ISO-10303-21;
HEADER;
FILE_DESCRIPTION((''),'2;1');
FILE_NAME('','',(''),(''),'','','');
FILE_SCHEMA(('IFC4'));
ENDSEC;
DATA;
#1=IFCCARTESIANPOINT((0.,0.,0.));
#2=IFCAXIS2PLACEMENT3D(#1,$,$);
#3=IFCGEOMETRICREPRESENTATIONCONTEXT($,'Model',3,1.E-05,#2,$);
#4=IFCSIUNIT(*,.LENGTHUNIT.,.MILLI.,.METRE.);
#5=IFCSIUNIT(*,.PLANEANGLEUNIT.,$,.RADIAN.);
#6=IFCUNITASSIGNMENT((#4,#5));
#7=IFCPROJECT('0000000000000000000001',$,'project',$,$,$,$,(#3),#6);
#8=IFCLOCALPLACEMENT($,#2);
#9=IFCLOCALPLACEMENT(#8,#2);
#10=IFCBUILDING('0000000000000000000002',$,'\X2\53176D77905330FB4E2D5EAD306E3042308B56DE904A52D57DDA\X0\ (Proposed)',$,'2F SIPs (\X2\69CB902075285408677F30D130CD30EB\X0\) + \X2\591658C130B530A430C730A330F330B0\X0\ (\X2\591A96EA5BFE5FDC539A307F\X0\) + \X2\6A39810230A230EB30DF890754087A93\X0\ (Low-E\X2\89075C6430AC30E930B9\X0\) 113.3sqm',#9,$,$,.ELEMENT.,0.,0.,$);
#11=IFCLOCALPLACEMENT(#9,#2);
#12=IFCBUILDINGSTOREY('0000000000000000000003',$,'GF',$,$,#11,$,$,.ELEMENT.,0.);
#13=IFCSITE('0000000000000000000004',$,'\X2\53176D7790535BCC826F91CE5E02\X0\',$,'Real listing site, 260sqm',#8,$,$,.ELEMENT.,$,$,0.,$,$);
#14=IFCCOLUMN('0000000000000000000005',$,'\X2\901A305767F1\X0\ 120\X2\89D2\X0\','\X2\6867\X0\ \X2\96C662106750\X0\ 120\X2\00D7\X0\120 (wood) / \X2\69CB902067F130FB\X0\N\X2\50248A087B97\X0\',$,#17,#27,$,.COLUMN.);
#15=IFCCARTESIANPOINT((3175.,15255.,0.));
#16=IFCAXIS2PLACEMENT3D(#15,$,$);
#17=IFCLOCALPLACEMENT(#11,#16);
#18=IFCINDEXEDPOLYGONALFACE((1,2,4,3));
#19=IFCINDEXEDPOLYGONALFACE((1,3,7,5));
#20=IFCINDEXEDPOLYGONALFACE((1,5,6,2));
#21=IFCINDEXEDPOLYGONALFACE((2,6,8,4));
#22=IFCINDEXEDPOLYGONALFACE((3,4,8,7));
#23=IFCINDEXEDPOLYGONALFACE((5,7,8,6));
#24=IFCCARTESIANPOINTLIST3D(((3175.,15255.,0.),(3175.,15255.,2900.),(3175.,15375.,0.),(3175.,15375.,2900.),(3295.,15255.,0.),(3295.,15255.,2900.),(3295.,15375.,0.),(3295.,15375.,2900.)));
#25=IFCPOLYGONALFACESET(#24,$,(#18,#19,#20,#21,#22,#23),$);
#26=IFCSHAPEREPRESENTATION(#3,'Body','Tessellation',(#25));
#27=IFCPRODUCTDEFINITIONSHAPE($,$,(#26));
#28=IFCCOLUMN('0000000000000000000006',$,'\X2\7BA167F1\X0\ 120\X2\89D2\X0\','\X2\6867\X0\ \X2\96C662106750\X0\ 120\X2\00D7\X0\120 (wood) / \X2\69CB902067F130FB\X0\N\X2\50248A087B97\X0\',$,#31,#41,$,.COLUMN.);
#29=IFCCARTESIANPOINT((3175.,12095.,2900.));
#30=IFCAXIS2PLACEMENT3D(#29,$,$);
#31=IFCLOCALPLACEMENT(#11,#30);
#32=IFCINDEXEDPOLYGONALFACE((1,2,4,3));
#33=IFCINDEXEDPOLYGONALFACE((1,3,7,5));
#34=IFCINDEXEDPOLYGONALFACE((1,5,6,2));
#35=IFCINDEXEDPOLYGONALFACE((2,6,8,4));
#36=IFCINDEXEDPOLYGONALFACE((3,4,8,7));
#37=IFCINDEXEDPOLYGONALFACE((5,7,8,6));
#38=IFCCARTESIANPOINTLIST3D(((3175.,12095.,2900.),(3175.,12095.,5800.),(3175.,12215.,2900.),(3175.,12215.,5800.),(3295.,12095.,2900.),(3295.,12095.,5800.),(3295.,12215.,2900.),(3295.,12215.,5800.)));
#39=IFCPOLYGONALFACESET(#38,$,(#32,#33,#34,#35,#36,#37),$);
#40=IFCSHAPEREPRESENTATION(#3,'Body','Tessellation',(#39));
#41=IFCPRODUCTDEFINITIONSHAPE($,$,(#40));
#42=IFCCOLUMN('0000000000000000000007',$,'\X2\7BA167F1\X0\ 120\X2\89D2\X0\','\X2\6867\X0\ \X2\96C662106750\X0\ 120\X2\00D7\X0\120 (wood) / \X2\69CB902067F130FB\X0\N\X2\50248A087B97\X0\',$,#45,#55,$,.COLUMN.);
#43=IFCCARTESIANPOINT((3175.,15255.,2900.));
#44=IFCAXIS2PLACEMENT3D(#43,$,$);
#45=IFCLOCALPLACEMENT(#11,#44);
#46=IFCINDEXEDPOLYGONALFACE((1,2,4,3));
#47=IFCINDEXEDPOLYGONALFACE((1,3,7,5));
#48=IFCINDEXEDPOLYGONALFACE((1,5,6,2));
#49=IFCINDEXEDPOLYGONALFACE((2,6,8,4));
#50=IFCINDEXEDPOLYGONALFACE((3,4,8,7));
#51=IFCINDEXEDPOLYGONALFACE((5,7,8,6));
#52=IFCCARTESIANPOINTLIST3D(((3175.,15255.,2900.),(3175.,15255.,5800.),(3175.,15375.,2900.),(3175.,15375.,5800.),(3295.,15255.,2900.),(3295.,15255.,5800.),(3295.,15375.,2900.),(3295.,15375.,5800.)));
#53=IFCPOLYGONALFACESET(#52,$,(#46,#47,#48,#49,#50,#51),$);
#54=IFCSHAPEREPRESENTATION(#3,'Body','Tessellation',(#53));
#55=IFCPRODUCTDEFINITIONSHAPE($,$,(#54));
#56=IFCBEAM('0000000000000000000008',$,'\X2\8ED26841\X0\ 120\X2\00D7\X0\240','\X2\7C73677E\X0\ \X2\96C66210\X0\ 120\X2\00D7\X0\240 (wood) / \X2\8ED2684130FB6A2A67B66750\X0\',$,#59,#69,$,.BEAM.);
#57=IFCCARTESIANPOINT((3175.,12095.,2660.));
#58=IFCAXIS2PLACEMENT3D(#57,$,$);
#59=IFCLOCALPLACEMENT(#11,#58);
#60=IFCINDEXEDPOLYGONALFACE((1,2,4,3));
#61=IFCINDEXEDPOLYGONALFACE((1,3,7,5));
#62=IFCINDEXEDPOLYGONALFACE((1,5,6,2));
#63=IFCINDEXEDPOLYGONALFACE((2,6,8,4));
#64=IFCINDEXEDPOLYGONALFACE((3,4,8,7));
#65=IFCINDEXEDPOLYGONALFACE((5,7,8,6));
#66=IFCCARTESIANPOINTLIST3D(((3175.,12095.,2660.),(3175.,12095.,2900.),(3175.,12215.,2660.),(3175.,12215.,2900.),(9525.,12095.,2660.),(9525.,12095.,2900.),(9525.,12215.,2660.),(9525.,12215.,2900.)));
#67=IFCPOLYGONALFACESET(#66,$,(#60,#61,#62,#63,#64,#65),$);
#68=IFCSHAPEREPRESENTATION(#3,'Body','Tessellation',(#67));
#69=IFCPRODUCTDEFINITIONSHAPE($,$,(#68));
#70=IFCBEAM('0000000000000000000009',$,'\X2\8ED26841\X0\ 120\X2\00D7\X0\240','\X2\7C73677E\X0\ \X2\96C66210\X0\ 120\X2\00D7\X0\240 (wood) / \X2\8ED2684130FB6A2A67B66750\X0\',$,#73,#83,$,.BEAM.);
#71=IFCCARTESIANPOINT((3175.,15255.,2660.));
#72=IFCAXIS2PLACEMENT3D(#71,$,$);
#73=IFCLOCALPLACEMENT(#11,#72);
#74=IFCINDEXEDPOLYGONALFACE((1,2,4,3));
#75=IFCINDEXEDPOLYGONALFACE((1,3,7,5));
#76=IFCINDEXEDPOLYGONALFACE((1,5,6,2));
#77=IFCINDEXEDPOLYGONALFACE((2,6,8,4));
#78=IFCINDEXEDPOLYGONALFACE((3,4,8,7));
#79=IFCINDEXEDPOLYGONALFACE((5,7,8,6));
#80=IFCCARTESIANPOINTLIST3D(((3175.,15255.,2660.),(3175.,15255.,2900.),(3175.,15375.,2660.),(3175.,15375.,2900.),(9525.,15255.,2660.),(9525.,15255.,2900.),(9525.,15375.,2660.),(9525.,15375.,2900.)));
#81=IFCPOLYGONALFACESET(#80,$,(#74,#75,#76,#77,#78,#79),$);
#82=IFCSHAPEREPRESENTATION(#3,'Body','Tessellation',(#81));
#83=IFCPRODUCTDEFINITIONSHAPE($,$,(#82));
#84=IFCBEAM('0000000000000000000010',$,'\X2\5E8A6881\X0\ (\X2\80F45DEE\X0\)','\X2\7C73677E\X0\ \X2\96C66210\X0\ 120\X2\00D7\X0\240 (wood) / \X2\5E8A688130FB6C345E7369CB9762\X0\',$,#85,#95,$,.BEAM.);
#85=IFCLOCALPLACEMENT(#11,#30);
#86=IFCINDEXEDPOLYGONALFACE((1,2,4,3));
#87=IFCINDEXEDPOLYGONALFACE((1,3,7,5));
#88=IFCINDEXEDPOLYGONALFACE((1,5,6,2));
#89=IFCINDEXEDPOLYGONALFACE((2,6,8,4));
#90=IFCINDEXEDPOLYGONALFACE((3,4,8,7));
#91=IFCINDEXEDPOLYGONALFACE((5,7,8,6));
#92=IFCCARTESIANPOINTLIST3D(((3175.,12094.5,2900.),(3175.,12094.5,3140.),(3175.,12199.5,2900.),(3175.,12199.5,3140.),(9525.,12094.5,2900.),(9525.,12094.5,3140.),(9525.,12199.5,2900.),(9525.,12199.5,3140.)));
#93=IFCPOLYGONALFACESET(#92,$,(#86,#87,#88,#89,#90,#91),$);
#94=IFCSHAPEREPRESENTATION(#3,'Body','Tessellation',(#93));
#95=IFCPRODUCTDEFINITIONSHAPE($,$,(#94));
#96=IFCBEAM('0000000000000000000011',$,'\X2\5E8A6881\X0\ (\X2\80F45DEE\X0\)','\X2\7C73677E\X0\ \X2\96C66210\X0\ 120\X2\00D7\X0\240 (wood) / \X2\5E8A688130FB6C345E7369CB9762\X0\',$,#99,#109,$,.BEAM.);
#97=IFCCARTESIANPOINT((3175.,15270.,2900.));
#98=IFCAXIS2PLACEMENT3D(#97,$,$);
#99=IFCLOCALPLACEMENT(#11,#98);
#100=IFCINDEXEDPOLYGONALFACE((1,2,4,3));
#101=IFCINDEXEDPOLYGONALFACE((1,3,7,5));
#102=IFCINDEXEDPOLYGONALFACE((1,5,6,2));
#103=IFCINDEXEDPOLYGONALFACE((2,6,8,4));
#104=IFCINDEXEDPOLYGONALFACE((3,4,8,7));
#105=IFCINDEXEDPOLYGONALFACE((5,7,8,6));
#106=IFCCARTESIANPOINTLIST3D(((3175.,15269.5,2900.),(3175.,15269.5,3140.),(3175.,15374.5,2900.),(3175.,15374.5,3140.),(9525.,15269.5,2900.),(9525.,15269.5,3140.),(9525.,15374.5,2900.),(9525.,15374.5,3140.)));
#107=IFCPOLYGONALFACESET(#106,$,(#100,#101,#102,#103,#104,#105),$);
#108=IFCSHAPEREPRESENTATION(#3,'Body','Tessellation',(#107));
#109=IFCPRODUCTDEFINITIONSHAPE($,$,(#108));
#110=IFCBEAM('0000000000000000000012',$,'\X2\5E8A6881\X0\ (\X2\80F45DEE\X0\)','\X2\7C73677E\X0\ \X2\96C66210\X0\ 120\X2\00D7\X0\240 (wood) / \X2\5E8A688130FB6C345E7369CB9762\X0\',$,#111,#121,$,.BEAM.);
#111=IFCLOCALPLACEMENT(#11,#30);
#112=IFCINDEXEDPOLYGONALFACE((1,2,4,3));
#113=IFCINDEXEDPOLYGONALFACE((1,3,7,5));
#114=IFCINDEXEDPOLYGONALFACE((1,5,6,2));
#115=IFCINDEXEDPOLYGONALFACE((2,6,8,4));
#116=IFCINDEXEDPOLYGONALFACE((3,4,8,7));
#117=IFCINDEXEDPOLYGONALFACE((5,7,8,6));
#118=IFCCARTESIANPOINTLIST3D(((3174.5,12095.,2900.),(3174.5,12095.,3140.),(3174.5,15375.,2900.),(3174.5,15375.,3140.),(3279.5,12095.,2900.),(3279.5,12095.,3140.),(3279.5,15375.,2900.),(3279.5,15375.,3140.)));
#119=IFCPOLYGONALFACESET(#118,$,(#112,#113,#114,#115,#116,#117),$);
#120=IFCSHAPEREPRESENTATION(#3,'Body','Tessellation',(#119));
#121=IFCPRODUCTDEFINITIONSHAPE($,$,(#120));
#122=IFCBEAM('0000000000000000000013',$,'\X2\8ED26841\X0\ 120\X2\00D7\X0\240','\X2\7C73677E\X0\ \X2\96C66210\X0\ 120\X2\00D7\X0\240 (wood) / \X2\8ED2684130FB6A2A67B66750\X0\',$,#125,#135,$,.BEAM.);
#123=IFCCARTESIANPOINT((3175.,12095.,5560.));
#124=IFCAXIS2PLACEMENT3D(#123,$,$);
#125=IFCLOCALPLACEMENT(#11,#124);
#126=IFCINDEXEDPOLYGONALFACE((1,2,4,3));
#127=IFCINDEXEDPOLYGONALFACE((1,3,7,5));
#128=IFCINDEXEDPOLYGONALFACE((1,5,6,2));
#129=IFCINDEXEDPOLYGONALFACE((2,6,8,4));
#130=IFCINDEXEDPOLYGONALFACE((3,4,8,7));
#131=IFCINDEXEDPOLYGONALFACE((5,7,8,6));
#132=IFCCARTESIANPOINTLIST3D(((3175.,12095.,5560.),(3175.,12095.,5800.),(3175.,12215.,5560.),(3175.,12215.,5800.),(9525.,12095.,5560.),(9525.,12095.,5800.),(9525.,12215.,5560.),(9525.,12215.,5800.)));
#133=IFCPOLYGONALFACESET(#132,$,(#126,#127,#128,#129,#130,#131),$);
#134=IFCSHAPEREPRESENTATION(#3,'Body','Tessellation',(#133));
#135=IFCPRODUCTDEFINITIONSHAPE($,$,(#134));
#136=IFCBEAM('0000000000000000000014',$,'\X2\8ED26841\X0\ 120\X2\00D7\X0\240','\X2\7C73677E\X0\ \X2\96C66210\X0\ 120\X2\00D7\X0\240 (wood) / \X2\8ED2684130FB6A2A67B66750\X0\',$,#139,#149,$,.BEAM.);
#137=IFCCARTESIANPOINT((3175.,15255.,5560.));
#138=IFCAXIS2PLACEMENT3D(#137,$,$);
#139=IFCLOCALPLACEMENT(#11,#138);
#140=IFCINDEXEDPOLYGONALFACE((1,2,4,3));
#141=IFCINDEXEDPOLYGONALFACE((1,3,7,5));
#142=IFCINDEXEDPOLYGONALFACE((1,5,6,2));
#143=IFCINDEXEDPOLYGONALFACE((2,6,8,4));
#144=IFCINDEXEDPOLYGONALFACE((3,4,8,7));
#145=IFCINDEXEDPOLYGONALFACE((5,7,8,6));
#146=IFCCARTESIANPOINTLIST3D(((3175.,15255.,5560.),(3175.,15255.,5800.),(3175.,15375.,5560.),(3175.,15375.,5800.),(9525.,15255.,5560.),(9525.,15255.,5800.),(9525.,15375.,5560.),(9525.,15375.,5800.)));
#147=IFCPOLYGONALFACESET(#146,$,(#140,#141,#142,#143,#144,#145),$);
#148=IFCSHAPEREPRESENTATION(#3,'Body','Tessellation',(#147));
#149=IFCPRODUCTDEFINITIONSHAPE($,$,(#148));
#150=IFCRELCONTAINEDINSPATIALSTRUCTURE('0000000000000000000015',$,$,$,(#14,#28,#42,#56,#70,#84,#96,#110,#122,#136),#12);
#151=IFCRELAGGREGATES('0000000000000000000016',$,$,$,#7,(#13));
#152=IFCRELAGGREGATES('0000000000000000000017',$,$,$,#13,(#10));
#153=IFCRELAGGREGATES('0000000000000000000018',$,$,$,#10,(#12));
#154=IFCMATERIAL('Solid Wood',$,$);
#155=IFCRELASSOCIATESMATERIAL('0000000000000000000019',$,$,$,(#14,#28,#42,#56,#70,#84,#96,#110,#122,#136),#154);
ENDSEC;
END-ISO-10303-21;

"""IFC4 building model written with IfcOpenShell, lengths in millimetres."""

from ifc_helpers import new_model, si_unit, frame, frame_2d, origin, place, context, project, spatial, rectangle, extrude, material, element, save


model = new_model("IFC4")

# Units and contexts
model_context = context("Model", 3, precision=1e-05, world=origin())
ifc_project = project(units=[si_unit("LENGTHUNIT", "METRE", prefix="MILLI"), si_unit("PLANEANGLEUNIT", "RADIAN")], contexts=[model_context])

# Site, building, storey
site_placement = place(None, origin())
site = spatial("IfcSite", under=ifc_project, at=site_placement, Name="北海道富良野市", ObjectType="Real listing site, 260sqm", CompositionType="ELEMENT", RefElevation=0.0)
building_placement = place(site_placement, origin())
building = spatial("IfcBuilding", under=site, at=building_placement, Name="北海道・中庭のある回遊動線 (Proposed)", ObjectType="2F SIPs (構造用合板パネル) + 外壁サイディング (多雪対応厚み) + 樹脂アルミ複合窓 (Low-E複層ガラス) 113.3sqm", CompositionType="ELEMENT", ElevationOfRefHeight=0.0, ElevationOfTerrain=0.0)
storey_placement = place(building_placement, origin())
storey = spatial("IfcBuildingStorey", under=building, at=storey_placement, Name="GF", CompositionType="ELEMENT", Elevation=0.0)

# Columns
ifc_material_1 = material(Name="Solid Wood")
column_1_placement = place(storey_placement, frame((3175.0, 15255.0, 0.0)))
element("IfcColumn", 1, at=column_1_placement, inside=storey, material=ifc_material_1, Name="通し柱 120角", Description="桧 集成材 120×120 (wood) / 構造柱・N値計算", PredefinedType="COLUMN", context=model_context, shape_type="SweptSolid", body=[
    extrude(rectangle(XDim=120.0, YDim=120.0, at=frame_2d((60.0, 60.0))), frame((3175.0, 15255.0, 0.0)), (0.0, 0.0, 1.0), 2900.0),
])
column_2_placement = place(storey_placement, frame((3175.0, 12095.0, 2900.0)))
element("IfcColumn", 2, at=column_2_placement, inside=storey, material=ifc_material_1, Name="管柱 120角", Description="桧 集成材 120×120 (wood) / 構造柱・N値計算", PredefinedType="COLUMN", context=model_context, shape_type="SweptSolid", body=[
    extrude(rectangle(XDim=120.0, YDim=120.0, at=frame_2d((60.0, 60.0))), frame((3175.0, 12095.0, 2900.0)), (0.0, 0.0, 1.0), 2900.0),
])
column_3_placement = place(storey_placement, frame((3175.0, 15255.0, 2900.0)))
element("IfcColumn", 3, at=column_3_placement, inside=storey, material=ifc_material_1, Name="管柱 120角", Description="桧 集成材 120×120 (wood) / 構造柱・N値計算", PredefinedType="COLUMN", context=model_context, shape_type="SweptSolid", body=[
    extrude(rectangle(XDim=120.0, YDim=120.0, at=frame_2d((60.0, 60.0))), frame((3175.0, 15255.0, 2900.0)), (0.0, 0.0, 1.0), 2900.0),
])

# Beams
beam_1_placement = place(storey_placement, frame((3175.0, 12095.0, 2660.0)))
element("IfcBeam", 4, at=beam_1_placement, inside=storey, material=ifc_material_1, Name="軒桁 120×240", Description="米松 集成 120×240 (wood) / 軒桁・横架材", PredefinedType="BEAM", context=model_context, shape_type="SweptSolid", body=[
    extrude(rectangle(XDim=6350.0, YDim=120.0, at=frame_2d((3175.0, 60.0))), frame((3175.0, 12095.0, 2660.0)), (0.0, 0.0, 1.0), 240.0),
])
beam_2_placement = place(storey_placement, frame((3175.0, 15255.0, 2660.0)))
element("IfcBeam", 5, at=beam_2_placement, inside=storey, material=ifc_material_1, Name="軒桁 120×240", Description="米松 集成 120×240 (wood) / 軒桁・横架材", PredefinedType="BEAM", context=model_context, shape_type="SweptSolid", body=[
    extrude(rectangle(XDim=6350.0, YDim=120.0, at=frame_2d((3175.0, 60.0))), frame((3175.0, 15255.0, 2660.0)), (0.0, 0.0, 1.0), 240.0),
])
beam_3_placement = place(storey_placement, frame((3175.0, 12095.0, 2900.0)))
element("IfcBeam", 6, at=beam_3_placement, inside=storey, material=ifc_material_1, Name="床梁 (胴差)", Description="米松 集成 120×240 (wood) / 床梁・水平構面", PredefinedType="BEAM", context=model_context, shape_type="SweptSolid", body=[
    extrude(rectangle(XDim=6350.0, YDim=105.0, at=frame_2d((3175.0, 52.0))), frame((3175.0, 12095.0, 2900.0)), (0.0, 0.0, 1.0), 240.0),
])
beam_4_placement = place(storey_placement, frame((3175.0, 15270.0, 2900.0)))
element("IfcBeam", 7, at=beam_4_placement, inside=storey, material=ifc_material_1, Name="床梁 (胴差)", Description="米松 集成 120×240 (wood) / 床梁・水平構面", PredefinedType="BEAM", context=model_context, shape_type="SweptSolid", body=[
    extrude(rectangle(XDim=6350.0, YDim=105.0, at=frame_2d((3175.0, 52.0))), frame((3175.0, 15270.0, 2900.0)), (0.0, 0.0, 1.0), 240.0),
])
beam_5_placement = place(storey_placement, frame((3175.0, 12095.0, 2900.0)))
element("IfcBeam", 8, at=beam_5_placement, inside=storey, material=ifc_material_1, Name="床梁 (胴差)", Description="米松 集成 120×240 (wood) / 床梁・水平構面", PredefinedType="BEAM", context=model_context, shape_type="SweptSolid", body=[
    extrude(rectangle(XDim=105.0, YDim=3280.0, at=frame_2d((52.0, 1640.0))), frame((3175.0, 12095.0, 2900.0)), (0.0, 0.0, 1.0), 240.0),
])
beam_6_placement = place(storey_placement, frame((3175.0, 12095.0, 5560.0)))
element("IfcBeam", 9, at=beam_6_placement, inside=storey, material=ifc_material_1, Name="軒桁 120×240", Description="米松 集成 120×240 (wood) / 軒桁・横架材", PredefinedType="BEAM", context=model_context, shape_type="SweptSolid", body=[
    extrude(rectangle(XDim=6350.0, YDim=120.0, at=frame_2d((3175.0, 60.0))), frame((3175.0, 12095.0, 5560.0)), (0.0, 0.0, 1.0), 240.0),
])
beam_7_placement = place(storey_placement, frame((3175.0, 15255.0, 5560.0)))
element("IfcBeam", 10, at=beam_7_placement, inside=storey, material=ifc_material_1, Name="軒桁 120×240", Description="米松 集成 120×240 (wood) / 軒桁・横架材", PredefinedType="BEAM", context=model_context, shape_type="SweptSolid", body=[
    extrude(rectangle(XDim=6350.0, YDim=120.0, at=frame_2d((3175.0, 60.0))), frame((3175.0, 15255.0, 5560.0)), (0.0, 0.0, 1.0), 240.0),
])

save(model, "model.ifc")
